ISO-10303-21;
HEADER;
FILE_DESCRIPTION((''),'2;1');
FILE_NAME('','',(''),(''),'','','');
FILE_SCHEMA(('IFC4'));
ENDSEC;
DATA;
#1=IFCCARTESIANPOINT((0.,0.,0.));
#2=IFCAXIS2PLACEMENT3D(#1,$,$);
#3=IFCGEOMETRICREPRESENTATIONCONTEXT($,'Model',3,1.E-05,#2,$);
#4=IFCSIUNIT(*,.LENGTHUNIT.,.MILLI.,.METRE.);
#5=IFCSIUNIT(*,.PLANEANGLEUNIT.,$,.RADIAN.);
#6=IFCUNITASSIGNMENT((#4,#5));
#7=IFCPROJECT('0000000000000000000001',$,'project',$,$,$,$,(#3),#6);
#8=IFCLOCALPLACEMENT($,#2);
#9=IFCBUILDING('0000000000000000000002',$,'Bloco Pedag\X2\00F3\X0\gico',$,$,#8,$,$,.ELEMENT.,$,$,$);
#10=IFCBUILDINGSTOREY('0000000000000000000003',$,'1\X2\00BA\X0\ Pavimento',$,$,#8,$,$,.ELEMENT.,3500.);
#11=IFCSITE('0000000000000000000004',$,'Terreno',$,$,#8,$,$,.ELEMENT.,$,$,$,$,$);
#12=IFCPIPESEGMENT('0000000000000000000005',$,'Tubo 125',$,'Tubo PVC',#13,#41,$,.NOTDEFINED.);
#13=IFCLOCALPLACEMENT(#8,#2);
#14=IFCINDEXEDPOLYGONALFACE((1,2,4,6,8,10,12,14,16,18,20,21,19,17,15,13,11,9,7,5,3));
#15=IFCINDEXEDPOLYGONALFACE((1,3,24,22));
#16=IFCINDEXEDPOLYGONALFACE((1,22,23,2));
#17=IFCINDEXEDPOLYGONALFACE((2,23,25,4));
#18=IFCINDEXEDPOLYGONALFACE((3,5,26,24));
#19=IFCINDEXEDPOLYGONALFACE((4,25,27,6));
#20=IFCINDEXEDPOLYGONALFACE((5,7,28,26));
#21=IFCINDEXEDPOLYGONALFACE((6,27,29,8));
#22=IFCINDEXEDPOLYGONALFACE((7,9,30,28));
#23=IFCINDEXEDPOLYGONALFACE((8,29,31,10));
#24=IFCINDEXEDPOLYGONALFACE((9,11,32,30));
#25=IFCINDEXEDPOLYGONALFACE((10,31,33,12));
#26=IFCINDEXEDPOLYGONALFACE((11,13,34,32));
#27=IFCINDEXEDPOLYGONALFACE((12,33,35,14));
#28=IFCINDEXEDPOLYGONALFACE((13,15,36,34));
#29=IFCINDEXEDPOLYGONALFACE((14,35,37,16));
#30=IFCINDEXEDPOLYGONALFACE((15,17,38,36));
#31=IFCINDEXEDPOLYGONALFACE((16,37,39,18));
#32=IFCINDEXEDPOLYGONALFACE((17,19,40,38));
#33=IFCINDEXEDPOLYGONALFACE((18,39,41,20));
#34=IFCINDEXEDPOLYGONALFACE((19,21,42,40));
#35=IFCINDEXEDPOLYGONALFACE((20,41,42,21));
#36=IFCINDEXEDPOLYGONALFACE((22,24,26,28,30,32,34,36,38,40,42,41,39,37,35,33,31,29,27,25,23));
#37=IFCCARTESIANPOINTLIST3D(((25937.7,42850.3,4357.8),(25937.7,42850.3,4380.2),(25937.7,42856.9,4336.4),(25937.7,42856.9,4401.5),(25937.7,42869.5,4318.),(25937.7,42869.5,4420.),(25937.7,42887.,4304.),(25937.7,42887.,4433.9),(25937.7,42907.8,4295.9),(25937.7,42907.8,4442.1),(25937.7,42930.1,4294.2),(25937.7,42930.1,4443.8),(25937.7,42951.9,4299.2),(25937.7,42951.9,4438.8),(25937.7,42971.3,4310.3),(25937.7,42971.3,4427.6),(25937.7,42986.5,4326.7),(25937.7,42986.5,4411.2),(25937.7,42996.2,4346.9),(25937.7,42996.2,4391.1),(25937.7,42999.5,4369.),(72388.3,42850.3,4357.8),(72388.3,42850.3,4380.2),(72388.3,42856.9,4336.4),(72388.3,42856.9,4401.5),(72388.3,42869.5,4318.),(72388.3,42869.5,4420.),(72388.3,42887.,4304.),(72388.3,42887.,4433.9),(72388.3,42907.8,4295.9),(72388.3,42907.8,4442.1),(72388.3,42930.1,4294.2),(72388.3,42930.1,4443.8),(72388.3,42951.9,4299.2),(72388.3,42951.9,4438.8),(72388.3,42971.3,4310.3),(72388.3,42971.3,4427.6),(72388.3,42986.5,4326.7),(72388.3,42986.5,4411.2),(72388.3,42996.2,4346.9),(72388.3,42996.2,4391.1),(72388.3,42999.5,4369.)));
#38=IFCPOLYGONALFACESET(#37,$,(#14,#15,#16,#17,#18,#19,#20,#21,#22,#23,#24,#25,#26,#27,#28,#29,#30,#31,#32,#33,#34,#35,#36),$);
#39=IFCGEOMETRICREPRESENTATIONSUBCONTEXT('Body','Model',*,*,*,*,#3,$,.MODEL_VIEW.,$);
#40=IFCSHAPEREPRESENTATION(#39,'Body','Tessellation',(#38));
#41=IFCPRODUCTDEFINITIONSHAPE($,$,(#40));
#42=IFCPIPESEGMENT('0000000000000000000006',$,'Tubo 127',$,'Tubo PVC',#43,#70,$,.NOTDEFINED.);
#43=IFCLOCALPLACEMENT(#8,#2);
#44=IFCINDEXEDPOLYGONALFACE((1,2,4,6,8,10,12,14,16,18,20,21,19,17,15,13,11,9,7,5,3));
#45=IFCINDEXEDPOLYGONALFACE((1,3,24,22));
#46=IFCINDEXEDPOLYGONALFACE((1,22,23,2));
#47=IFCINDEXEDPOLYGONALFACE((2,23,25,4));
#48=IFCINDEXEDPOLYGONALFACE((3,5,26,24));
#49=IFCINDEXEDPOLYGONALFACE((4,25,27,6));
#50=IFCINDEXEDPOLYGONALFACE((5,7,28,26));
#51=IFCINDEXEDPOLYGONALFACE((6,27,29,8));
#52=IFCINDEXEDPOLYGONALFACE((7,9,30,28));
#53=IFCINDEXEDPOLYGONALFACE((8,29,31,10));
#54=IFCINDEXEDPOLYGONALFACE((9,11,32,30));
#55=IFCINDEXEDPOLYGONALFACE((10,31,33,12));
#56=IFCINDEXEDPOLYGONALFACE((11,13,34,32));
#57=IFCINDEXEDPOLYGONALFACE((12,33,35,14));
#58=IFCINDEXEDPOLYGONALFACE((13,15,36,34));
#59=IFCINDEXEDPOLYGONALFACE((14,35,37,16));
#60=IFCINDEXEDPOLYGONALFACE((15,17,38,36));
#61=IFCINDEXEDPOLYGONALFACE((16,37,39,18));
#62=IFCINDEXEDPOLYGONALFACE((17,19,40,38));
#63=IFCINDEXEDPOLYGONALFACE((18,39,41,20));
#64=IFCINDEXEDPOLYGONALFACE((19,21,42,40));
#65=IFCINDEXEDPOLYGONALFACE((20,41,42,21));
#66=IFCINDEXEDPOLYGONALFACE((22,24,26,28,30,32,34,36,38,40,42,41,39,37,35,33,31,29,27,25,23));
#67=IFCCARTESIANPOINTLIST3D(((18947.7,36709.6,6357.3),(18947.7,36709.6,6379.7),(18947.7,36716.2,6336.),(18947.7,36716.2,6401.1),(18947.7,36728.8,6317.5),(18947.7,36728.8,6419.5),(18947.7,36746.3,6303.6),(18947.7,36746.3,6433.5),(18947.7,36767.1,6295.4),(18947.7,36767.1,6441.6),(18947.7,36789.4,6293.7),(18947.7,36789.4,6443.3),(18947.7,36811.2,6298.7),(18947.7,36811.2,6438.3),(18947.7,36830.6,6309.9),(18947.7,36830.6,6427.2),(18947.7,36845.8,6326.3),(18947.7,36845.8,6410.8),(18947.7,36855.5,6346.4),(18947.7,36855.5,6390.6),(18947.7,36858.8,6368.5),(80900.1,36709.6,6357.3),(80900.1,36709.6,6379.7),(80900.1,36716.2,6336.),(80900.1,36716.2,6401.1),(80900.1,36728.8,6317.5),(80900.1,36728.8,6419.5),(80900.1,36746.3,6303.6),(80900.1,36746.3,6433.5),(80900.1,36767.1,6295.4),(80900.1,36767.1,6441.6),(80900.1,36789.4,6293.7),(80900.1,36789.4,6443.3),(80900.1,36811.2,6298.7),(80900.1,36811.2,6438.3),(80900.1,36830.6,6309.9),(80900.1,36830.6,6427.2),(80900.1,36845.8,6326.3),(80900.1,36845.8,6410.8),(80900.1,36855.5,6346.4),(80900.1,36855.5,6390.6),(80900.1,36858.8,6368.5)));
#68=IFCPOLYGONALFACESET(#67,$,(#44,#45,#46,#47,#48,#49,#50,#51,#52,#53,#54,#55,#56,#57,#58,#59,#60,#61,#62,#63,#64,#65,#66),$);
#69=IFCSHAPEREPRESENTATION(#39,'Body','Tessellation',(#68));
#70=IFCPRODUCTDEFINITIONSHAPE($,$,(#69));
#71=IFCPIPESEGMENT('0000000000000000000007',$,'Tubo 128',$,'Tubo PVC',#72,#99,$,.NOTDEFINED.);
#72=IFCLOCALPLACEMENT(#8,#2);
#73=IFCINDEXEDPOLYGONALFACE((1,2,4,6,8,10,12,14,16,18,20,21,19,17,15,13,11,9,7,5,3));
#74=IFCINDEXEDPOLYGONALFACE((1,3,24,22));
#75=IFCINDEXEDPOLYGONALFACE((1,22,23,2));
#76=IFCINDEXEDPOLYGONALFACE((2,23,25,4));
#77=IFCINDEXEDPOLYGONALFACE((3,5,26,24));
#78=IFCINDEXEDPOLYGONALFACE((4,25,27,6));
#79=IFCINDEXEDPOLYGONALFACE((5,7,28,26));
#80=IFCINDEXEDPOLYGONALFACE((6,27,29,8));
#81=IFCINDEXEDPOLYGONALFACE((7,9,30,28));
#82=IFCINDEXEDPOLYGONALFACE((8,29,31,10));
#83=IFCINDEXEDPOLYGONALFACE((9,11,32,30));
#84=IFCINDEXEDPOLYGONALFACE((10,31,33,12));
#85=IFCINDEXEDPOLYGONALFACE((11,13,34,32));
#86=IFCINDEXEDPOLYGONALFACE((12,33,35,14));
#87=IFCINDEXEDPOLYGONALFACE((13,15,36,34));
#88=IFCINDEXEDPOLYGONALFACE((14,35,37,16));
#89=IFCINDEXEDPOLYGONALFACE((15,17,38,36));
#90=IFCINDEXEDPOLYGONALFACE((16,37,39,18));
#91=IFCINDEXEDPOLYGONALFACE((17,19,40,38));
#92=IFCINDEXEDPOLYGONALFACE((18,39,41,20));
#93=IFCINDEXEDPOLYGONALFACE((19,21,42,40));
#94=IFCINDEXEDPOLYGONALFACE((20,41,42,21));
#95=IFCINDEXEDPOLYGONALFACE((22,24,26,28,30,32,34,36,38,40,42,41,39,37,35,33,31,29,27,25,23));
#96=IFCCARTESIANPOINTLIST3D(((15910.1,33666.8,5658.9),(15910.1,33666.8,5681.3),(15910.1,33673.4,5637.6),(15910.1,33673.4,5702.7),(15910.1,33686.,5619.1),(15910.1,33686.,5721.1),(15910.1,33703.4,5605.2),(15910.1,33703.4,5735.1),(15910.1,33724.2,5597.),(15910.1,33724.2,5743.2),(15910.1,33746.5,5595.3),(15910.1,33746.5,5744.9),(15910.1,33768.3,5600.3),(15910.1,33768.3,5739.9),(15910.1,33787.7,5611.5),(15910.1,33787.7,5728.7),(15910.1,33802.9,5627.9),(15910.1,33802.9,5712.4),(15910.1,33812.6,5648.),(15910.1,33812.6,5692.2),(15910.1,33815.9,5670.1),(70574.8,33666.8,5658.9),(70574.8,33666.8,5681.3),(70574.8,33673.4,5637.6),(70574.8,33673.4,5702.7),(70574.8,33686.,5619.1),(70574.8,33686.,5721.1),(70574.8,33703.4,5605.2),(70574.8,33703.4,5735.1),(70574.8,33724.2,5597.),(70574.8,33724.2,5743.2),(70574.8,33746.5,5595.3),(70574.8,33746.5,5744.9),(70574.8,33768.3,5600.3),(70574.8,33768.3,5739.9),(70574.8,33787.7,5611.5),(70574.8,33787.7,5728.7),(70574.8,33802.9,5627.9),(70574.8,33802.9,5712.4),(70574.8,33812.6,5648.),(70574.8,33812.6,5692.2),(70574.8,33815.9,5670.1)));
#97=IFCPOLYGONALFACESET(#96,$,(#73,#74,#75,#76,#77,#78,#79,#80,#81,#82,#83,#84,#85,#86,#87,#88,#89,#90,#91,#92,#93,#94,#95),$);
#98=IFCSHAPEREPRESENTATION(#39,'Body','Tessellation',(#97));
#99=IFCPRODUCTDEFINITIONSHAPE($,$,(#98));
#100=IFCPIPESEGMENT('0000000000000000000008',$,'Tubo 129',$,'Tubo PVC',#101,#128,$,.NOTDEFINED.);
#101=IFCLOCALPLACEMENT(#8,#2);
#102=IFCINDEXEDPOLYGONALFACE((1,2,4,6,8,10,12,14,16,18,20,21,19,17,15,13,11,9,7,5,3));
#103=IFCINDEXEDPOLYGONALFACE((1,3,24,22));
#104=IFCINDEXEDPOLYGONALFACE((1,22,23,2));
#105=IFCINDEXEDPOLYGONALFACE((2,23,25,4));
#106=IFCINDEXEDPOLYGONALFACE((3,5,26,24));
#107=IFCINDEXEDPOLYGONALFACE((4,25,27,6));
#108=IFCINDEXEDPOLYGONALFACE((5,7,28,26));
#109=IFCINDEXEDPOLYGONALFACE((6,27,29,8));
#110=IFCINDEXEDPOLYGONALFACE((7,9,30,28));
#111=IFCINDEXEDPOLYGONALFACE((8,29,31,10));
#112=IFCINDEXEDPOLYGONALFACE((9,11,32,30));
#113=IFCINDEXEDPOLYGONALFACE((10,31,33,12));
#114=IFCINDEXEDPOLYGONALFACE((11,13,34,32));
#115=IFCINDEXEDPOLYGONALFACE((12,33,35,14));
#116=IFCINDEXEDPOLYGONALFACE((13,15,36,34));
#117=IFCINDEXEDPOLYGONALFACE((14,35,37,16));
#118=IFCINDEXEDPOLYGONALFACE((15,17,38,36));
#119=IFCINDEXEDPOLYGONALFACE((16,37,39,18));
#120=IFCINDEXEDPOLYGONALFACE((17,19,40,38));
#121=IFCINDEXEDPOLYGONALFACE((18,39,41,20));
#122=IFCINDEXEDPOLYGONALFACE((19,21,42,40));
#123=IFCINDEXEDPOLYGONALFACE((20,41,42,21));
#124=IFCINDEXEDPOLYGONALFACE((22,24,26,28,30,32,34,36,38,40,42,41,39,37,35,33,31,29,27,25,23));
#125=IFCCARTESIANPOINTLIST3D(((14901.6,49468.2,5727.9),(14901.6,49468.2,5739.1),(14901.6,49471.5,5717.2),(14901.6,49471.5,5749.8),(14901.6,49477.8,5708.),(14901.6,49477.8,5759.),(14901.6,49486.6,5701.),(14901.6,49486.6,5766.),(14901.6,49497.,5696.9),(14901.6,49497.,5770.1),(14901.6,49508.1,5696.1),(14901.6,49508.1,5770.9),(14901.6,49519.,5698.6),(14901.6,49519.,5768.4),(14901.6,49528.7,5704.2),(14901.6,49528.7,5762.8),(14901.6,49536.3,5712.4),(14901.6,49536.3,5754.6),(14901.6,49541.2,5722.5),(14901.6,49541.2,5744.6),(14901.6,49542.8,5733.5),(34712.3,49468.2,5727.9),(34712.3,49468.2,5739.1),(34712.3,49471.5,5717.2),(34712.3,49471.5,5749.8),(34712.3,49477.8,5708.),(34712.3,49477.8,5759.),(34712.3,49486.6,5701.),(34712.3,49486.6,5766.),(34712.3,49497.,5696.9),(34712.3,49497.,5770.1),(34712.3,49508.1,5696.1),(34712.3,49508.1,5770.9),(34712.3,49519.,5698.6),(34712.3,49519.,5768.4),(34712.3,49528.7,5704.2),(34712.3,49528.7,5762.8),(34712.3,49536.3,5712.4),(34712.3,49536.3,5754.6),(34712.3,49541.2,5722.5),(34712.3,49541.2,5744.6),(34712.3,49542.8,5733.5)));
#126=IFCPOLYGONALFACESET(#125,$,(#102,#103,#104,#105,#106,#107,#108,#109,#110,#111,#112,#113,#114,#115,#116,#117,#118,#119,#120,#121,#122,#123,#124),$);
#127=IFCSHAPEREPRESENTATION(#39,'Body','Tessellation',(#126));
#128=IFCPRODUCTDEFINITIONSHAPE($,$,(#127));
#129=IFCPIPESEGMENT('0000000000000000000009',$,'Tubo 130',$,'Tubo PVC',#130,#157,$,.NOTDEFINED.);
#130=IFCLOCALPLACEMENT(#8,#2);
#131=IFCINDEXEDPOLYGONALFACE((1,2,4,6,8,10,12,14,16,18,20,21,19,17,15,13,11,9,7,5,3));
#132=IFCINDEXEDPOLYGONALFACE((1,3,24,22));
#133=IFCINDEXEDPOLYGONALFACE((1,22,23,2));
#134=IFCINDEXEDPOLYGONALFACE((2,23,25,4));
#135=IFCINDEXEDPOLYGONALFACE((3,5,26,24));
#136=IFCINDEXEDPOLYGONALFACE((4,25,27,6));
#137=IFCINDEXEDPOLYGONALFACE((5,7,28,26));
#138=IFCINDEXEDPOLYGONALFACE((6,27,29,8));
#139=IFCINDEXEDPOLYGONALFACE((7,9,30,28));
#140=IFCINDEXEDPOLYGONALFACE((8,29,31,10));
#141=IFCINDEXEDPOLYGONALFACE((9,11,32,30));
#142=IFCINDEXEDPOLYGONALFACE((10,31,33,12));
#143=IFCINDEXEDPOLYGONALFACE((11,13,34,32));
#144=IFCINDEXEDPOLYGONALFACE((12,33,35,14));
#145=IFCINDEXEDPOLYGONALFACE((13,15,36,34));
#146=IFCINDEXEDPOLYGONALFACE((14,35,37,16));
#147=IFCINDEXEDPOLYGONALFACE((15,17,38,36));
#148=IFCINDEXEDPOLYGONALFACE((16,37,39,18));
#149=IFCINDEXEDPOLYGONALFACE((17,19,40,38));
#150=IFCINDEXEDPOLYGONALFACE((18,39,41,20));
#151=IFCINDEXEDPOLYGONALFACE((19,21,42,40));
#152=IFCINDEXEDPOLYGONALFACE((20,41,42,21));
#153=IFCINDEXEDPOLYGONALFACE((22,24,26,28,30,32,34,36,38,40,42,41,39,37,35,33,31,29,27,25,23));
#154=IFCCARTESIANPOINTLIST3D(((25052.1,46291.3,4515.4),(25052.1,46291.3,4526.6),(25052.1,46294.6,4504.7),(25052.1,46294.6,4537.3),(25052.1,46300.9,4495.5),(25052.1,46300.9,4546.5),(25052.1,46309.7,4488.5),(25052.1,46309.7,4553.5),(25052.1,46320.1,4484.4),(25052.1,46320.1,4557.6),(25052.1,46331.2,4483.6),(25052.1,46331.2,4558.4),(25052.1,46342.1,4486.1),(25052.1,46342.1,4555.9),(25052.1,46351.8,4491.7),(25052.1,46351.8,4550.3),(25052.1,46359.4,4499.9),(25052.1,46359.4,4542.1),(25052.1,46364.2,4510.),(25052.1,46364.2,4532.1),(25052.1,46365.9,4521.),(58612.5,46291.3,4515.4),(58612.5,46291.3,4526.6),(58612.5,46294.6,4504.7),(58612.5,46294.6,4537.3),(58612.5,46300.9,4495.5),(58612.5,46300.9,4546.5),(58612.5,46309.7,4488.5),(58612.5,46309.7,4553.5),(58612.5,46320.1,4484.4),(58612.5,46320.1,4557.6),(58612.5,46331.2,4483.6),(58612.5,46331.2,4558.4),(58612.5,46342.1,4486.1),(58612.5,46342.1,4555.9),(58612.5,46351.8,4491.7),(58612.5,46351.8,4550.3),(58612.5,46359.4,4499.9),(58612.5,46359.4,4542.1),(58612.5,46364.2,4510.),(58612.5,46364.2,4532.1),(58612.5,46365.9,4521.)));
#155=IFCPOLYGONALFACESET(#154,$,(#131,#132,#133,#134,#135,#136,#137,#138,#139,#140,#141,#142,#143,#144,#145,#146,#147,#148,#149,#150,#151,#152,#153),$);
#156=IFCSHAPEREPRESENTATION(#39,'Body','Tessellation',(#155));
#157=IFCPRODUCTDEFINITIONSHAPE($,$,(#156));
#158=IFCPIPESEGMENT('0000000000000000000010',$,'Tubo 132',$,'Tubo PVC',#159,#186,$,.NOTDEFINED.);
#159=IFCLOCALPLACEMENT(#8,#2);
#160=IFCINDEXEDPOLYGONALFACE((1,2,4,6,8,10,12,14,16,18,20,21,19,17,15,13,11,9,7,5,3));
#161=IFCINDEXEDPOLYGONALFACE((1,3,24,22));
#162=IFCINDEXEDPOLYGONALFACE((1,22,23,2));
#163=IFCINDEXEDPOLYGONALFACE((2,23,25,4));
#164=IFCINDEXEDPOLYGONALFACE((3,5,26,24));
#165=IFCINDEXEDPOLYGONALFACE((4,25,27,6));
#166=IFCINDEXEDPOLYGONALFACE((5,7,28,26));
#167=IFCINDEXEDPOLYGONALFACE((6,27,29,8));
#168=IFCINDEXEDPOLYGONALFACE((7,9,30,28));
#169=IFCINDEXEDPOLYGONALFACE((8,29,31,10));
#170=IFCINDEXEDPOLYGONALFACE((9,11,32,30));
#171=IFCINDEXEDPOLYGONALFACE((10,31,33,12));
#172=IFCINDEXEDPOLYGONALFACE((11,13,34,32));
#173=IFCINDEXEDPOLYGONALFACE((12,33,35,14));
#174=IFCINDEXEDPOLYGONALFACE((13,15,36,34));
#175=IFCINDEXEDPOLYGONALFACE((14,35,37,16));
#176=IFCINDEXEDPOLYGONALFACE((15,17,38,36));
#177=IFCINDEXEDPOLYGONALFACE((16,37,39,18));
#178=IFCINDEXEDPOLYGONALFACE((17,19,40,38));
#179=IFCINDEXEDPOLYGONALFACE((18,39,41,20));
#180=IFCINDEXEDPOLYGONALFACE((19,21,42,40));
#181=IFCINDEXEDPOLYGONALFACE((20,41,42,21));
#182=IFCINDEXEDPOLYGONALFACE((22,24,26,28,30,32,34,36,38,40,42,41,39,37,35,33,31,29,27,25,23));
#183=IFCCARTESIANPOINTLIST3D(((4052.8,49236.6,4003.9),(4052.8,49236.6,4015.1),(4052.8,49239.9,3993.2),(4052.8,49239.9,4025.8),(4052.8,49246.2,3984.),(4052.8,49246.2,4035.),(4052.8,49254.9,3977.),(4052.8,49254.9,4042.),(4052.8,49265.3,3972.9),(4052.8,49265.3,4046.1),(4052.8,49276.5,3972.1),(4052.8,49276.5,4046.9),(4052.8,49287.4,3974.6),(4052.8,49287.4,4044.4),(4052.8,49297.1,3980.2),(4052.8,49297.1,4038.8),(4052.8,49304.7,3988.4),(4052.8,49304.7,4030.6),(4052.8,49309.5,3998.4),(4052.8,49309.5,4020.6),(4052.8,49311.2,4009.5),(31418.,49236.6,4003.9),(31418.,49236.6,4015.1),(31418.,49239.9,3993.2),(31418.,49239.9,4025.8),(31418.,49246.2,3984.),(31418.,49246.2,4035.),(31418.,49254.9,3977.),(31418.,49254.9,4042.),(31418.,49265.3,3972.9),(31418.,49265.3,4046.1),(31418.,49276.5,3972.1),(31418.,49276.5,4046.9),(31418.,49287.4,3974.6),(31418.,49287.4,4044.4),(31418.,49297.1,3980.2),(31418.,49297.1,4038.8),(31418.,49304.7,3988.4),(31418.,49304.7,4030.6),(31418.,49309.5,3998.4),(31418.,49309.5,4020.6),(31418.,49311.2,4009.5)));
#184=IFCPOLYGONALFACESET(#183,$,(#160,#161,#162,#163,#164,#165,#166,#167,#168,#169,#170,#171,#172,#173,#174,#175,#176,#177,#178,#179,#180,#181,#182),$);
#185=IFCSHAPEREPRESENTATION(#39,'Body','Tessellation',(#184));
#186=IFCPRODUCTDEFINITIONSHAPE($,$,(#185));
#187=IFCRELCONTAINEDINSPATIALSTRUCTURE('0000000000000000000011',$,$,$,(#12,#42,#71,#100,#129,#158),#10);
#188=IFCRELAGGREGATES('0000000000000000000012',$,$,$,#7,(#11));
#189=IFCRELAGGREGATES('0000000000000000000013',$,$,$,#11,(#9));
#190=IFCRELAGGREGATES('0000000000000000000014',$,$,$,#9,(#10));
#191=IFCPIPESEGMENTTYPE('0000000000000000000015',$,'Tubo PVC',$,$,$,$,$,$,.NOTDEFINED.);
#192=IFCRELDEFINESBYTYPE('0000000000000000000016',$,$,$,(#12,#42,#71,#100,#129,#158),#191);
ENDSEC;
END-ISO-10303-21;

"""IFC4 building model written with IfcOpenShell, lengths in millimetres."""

from ifc_helpers import new_model, si_unit, frame, origin, origin_2d, place, context, subcontext, project, spatial, circle, extrude, type_object, element, save


model = new_model("IFC4")

# Units and contexts
model_context = context("Model", 3, precision=1e-05, world=origin())
body_context = subcontext(model_context, "Body", "Model", "MODEL_VIEW")
ifc_project = project(units=[si_unit("LENGTHUNIT", "METRE", prefix="MILLI"), si_unit("PLANEANGLEUNIT", "RADIAN")], contexts=[model_context])

# Site, building, storey
placement = place(None, origin())
site = spatial("IfcSite", under=ifc_project, at=placement, Name="Terreno", CompositionType="ELEMENT")
building = spatial("IfcBuilding", under=site, at=placement, Name="Bloco Pedagógico", CompositionType="ELEMENT")
storey = spatial("IfcBuildingStorey", under=building, at=placement, Name="1º Pavimento", CompositionType="ELEMENT", Elevation=3500.0)

# Pipe segments
pipe_segment_type = type_object("IfcPipeSegmentType", Name="Tubo PVC", PredefinedType="NOTDEFINED")
pipe_segment_1_placement = place(None, frame((25937.7, 42924.5, 4369.0), z_axis=(1.0, 0.0, 0.0), x_axis=(0.0, 1.0, 0.0)))
element("IfcPipeSegment", 1, at=pipe_segment_1_placement, inside=storey, type_object=pipe_segment_type, Name="Tubo 125", ObjectType="Tubo PVC", PredefinedType="NOTDEFINED", context=body_context, shape_type="SweptSolid", body=[
    extrude(circle(Radius=75.0, at=origin_2d()), None, (0.0, 0.0, 1.0), 46450.6),
])
pipe_segment_2_placement = place(None, frame((18947.7, 36783.8, 6368.5), z_axis=(1.0, 0.0, 0.0), x_axis=(0.0, 1.0, 0.0)))
element("IfcPipeSegment", 2, at=pipe_segment_2_placement, inside=storey, type_object=pipe_segment_type, Name="Tubo 127", ObjectType="Tubo PVC", PredefinedType="NOTDEFINED", context=body_context, shape_type="SweptSolid", body=[
    extrude(circle(Radius=75.0, at=origin_2d()), None, (0.0, 0.0, 1.0), 61952.4),
])
pipe_segment_3_placement = place(None, frame((15910.1, 33740.9, 5670.1), z_axis=(1.0, 0.0, 0.0), x_axis=(0.0, 1.0, 0.0)))
element("IfcPipeSegment", 3, at=pipe_segment_3_placement, inside=storey, type_object=pipe_segment_type, Name="Tubo 128", ObjectType="Tubo PVC", PredefinedType="NOTDEFINED", context=body_context, shape_type="SweptSolid", body=[
    extrude(circle(Radius=75.0, at=origin_2d()), None, (0.0, 0.0, 1.0), 54664.7),
])
pipe_segment_4_placement = place(None, frame((14901.6, 49505.3, 5733.5), z_axis=(1.0, 0.0, 0.0), x_axis=(0.0, 1.0, 0.0)))
element("IfcPipeSegment", 4, at=pipe_segment_4_placement, inside=storey, type_object=pipe_segment_type, Name="Tubo 129", ObjectType="Tubo PVC", PredefinedType="NOTDEFINED", context=body_context, shape_type="SweptSolid", body=[
    extrude(circle(Radius=37.5, at=origin_2d()), None, (0.0, 0.0, 1.0), 19810.7),
])
pipe_segment_5_placement = place(None, frame((25052.1, 46328.4, 4521.0), z_axis=(1.0, 0.0, 0.0), x_axis=(0.0, 1.0, 0.0)))
element("IfcPipeSegment", 5, at=pipe_segment_5_placement, inside=storey, type_object=pipe_segment_type, Name="Tubo 130", ObjectType="Tubo PVC", PredefinedType="NOTDEFINED", context=body_context, shape_type="SweptSolid", body=[
    extrude(circle(Radius=37.5, at=origin_2d()), None, (0.0, 0.0, 1.0), 33560.4),
])
pipe_segment_6_placement = place(None, frame((4052.8, 49273.7, 4009.5), z_axis=(1.0, 0.0, 0.0), x_axis=(0.0, 1.0, 0.0)))
element("IfcPipeSegment", 6, at=pipe_segment_6_placement, inside=storey, type_object=pipe_segment_type, Name="Tubo 132", ObjectType="Tubo PVC", PredefinedType="NOTDEFINED", context=body_context, shape_type="SweptSolid", body=[
    extrude(circle(Radius=37.5, at=origin_2d()), None, (0.0, 0.0, 1.0), 27365.2),
])

save(model, "model.ifc")
